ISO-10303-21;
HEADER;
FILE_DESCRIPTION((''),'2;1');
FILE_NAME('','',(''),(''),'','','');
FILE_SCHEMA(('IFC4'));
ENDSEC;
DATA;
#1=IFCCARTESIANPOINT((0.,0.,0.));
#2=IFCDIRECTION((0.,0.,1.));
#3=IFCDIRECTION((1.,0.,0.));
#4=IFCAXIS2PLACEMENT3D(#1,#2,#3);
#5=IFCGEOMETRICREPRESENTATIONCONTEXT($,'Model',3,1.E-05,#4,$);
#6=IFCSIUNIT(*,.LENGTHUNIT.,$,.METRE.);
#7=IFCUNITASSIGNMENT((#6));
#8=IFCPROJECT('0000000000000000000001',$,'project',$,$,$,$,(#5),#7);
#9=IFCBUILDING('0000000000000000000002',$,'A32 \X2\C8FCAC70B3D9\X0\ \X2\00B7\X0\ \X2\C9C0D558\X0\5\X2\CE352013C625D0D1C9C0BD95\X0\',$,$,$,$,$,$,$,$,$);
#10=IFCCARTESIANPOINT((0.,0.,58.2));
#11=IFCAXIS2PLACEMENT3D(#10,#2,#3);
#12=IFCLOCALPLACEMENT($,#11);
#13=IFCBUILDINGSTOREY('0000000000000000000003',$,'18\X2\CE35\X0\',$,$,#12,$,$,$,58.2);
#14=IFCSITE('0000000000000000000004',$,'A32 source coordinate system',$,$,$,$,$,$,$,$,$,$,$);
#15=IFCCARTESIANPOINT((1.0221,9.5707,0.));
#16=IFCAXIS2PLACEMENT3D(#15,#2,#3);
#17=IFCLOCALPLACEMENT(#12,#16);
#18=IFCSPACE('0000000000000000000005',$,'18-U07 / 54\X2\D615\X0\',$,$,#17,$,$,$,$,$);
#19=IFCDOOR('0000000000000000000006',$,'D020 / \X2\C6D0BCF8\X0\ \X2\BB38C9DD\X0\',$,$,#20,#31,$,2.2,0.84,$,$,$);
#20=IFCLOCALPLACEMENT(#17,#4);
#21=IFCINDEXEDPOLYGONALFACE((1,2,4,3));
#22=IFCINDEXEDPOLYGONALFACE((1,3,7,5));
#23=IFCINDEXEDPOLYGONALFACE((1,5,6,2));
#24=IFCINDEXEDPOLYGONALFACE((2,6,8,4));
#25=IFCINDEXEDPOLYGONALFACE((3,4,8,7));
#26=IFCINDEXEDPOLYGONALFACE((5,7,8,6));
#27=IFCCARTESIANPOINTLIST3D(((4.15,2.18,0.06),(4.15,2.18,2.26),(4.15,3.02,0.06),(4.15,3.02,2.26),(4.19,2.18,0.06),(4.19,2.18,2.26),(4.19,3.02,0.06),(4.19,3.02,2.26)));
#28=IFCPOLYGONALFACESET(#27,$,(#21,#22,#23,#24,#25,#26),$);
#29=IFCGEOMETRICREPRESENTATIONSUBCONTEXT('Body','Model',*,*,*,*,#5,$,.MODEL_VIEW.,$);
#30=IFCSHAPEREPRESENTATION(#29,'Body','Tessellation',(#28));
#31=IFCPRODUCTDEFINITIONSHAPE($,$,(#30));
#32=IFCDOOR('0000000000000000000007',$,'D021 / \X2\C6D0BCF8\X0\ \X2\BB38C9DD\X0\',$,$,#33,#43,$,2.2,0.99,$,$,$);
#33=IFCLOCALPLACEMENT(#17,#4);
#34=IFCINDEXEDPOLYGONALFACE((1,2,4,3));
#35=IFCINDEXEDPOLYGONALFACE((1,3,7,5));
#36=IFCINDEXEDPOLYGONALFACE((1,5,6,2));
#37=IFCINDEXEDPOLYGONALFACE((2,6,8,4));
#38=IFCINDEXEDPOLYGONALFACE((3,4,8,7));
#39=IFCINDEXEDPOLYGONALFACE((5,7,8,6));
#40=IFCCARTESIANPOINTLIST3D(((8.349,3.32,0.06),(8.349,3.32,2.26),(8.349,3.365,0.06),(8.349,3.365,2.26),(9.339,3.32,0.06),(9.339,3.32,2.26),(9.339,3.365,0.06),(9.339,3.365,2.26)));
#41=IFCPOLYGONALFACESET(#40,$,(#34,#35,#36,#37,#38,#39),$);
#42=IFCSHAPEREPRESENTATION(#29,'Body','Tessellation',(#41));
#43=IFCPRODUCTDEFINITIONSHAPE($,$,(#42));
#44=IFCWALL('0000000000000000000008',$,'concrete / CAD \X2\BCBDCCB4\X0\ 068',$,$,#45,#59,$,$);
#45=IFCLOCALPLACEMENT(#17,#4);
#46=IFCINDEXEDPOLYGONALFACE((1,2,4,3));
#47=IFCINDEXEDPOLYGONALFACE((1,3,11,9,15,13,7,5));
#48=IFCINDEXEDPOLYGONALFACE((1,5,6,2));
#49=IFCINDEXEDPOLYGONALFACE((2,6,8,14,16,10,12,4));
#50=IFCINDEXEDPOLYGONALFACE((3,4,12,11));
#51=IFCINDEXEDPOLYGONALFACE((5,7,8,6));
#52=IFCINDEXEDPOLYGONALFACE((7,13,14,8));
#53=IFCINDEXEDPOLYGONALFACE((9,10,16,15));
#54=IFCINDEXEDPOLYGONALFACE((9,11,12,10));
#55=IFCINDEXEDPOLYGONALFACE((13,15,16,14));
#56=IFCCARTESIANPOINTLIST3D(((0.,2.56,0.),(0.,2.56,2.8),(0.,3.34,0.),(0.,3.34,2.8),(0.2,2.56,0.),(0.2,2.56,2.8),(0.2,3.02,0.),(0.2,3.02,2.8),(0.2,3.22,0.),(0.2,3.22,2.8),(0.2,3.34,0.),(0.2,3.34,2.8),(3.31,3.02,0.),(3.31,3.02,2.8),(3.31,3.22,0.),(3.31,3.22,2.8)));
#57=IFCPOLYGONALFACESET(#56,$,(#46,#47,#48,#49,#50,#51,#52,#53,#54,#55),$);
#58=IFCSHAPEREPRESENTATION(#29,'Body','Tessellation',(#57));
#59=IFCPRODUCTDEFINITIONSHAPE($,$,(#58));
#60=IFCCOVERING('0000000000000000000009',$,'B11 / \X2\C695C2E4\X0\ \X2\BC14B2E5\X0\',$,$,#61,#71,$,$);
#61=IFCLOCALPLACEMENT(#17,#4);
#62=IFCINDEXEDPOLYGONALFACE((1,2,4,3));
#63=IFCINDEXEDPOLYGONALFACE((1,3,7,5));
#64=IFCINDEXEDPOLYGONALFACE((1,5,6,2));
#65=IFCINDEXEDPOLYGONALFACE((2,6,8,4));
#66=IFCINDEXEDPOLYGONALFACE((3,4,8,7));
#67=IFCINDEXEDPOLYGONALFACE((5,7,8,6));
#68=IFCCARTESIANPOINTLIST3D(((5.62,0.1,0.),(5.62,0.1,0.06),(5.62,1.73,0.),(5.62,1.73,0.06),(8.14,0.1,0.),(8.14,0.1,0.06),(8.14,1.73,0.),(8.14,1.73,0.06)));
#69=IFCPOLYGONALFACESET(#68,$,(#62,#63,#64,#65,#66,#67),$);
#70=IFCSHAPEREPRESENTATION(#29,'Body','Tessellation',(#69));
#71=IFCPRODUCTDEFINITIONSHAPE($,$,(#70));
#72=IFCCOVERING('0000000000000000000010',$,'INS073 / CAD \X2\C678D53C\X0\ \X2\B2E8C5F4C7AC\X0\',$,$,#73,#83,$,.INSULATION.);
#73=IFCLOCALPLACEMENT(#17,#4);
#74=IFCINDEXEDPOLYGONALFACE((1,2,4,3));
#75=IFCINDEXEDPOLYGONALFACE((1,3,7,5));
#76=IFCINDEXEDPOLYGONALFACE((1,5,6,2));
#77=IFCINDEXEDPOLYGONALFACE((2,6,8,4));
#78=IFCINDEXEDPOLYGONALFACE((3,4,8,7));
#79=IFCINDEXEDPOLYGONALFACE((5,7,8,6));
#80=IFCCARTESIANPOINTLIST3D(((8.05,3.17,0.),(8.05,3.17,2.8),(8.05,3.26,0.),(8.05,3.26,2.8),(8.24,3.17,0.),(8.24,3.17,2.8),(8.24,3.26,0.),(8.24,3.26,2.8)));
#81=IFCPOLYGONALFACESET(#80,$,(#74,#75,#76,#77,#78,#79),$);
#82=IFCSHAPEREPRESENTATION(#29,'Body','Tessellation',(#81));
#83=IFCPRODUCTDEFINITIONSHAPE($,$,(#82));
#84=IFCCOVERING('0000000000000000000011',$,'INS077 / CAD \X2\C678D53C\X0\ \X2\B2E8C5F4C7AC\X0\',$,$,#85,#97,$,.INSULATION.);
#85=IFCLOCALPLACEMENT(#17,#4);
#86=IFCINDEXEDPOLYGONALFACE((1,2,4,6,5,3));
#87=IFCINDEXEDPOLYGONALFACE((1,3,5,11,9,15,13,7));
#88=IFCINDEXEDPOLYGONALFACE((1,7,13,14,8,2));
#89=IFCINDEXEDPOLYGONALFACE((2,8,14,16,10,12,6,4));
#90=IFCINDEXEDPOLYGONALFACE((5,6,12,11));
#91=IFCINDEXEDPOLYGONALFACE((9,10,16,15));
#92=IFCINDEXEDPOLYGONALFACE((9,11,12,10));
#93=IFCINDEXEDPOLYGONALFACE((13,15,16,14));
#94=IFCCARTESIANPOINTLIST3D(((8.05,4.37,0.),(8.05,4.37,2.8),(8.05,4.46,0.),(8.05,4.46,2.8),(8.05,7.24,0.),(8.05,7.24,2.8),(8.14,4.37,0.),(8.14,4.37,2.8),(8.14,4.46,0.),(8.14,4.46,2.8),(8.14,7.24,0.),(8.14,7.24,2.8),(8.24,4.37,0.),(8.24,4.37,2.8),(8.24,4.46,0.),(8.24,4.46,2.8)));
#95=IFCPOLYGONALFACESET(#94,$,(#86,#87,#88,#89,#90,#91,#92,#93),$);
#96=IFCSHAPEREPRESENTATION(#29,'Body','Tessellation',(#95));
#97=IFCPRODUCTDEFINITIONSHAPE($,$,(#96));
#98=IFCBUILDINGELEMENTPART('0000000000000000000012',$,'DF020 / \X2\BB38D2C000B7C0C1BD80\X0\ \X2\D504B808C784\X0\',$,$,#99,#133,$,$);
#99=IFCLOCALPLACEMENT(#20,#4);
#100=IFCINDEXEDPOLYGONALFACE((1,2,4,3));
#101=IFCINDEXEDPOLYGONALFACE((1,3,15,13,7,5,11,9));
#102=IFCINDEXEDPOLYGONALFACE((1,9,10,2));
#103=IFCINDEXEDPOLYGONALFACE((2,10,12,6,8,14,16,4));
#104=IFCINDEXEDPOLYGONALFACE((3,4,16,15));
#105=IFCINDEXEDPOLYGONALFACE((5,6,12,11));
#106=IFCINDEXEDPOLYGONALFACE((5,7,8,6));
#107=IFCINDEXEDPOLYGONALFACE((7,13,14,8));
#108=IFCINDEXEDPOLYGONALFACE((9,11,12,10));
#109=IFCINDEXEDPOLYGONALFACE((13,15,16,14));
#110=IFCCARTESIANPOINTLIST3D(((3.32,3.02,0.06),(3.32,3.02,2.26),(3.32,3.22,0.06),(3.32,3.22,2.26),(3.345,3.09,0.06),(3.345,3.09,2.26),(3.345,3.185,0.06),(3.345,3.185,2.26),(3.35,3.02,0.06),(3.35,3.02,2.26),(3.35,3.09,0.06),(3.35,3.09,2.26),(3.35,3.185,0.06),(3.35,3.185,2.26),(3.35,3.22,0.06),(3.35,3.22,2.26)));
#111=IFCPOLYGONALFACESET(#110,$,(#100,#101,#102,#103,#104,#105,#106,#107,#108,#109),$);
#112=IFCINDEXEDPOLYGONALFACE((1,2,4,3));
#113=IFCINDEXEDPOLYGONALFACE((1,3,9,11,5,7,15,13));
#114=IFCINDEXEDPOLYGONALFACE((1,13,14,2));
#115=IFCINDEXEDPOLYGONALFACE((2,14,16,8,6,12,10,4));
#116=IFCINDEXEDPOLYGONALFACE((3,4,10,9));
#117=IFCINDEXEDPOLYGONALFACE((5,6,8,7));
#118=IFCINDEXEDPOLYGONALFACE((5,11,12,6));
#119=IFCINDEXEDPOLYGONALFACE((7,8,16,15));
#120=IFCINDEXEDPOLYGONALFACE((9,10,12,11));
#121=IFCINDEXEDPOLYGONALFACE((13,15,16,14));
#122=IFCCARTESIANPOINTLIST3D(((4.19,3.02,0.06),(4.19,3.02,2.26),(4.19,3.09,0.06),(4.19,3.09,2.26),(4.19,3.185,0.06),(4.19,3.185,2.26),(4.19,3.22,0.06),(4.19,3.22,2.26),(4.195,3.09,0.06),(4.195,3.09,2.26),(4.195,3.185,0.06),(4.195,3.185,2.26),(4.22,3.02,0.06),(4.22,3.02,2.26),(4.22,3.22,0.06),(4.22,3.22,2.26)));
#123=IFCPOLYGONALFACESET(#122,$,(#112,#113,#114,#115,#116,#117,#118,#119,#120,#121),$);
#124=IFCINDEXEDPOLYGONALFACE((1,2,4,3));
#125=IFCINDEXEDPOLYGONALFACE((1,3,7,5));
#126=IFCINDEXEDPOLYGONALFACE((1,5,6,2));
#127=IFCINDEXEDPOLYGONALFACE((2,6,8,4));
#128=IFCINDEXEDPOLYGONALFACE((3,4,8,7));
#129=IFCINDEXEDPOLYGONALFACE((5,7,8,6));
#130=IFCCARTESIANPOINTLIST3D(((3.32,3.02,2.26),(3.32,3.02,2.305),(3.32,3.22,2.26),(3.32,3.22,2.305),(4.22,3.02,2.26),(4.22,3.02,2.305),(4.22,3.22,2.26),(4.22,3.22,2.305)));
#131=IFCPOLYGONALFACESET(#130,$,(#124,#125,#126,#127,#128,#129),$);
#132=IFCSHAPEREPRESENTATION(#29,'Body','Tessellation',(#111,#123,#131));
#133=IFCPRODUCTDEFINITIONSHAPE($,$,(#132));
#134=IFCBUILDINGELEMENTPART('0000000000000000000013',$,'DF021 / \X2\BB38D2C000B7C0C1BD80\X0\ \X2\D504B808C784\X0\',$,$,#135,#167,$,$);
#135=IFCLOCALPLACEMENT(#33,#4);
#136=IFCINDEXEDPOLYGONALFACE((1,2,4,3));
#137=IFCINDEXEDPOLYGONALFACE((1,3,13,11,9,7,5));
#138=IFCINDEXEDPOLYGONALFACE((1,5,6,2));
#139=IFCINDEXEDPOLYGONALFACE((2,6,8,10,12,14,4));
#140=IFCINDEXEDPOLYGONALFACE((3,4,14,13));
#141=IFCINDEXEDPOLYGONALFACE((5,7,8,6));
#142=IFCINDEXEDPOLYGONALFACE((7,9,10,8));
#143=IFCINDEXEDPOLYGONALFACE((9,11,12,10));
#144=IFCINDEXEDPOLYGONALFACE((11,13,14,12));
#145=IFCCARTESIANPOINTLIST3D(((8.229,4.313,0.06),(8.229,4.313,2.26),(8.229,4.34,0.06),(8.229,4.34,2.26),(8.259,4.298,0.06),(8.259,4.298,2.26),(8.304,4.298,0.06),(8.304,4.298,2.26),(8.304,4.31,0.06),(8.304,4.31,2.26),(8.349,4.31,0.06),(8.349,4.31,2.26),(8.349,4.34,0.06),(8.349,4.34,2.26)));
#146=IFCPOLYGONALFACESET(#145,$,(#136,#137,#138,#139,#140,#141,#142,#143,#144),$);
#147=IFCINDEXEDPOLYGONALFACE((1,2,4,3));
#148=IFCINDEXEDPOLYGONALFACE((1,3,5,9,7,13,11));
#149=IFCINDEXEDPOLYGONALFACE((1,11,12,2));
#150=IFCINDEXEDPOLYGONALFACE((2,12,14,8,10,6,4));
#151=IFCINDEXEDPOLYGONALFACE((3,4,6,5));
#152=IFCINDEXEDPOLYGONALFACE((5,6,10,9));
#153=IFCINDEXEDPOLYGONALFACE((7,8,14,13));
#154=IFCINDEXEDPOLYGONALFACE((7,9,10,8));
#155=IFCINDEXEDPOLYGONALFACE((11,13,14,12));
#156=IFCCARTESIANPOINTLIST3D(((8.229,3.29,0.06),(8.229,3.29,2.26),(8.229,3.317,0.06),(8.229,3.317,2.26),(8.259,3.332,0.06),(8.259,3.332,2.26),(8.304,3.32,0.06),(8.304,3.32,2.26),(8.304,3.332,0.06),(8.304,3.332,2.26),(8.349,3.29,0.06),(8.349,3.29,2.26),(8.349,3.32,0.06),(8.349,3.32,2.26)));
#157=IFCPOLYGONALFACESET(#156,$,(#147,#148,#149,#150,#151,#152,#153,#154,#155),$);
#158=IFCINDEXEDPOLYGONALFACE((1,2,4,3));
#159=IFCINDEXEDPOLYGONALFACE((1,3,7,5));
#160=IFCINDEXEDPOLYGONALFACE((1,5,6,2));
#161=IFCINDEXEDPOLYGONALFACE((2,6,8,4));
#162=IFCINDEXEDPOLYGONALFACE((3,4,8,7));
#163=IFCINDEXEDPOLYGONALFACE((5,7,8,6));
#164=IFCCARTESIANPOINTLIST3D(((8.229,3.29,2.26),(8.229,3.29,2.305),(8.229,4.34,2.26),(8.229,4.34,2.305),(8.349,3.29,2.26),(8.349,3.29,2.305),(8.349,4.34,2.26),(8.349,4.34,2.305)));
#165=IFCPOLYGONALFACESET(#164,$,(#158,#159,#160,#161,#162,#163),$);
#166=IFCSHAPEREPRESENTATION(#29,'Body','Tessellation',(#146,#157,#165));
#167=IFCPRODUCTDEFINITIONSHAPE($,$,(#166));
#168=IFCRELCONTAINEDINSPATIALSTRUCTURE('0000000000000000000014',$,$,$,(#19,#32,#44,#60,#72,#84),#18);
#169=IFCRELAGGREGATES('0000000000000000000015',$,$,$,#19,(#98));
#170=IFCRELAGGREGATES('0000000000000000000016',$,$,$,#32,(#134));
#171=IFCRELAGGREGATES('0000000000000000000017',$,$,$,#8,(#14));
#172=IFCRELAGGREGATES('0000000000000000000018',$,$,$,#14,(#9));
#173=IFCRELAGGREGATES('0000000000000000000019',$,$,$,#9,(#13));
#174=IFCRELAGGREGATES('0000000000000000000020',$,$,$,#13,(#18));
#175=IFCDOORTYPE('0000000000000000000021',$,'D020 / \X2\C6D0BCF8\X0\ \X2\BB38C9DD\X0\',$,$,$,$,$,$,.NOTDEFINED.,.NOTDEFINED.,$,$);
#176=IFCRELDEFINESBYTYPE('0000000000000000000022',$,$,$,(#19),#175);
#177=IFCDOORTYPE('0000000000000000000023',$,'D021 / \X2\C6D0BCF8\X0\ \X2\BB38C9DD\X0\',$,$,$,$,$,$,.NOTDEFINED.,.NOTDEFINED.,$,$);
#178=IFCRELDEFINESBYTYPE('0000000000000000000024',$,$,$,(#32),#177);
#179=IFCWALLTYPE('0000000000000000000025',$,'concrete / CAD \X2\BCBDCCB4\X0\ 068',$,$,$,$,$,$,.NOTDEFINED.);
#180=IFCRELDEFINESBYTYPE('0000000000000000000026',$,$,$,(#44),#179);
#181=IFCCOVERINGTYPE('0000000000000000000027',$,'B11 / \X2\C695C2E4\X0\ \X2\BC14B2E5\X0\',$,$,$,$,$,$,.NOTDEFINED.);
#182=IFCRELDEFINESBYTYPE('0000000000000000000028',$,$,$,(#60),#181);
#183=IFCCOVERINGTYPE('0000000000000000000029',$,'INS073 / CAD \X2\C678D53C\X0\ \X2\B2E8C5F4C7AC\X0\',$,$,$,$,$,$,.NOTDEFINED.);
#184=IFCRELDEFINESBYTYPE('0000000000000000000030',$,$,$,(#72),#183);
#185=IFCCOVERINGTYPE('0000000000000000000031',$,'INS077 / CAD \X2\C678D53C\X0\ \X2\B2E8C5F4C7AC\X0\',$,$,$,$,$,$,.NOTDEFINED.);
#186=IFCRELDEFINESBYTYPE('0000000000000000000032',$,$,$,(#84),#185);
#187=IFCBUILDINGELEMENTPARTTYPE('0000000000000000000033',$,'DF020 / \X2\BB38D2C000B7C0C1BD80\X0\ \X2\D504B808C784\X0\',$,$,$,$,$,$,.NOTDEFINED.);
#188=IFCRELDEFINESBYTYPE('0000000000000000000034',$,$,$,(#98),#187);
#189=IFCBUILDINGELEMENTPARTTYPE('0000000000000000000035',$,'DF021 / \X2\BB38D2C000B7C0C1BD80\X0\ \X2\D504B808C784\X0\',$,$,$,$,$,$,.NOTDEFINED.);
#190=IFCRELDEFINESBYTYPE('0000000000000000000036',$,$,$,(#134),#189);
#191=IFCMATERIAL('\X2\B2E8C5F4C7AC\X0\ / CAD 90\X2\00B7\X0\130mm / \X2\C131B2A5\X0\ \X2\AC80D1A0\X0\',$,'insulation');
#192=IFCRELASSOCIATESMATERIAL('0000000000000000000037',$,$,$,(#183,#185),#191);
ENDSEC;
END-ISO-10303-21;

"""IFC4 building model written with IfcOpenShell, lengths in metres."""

from ifc_helpers import new_model, si_unit, frame, origin, origin_with_axes, place, context, subcontext, project, spatial, polyline, outline, extrude, source, transform, mapped, material, type_object, type_shapes, element, aggregate, save


model = new_model("IFC4")

# Units and contexts
model_context = context("Model", 3, precision=1e-05, world=origin_with_axes())
body_context = subcontext(model_context, "Body", "Model", "MODEL_VIEW")
ifc_project = project(units=[si_unit("LENGTHUNIT", "METRE")], contexts=[model_context])

# Site, building, storey, space
storey_placement = place(None, frame((0.0, 0.0, 58.2), z_axis=(0.0, 0.0, 1.0), x_axis=(1.0, 0.0, 0.0)))
space_placement = place(storey_placement, frame((1.0221, 9.5707, 0.0), z_axis=(0.0, 0.0, 1.0), x_axis=(1.0, 0.0, 0.0)))
site = spatial("IfcSite", under=ifc_project, Name="A32 source coordinate system")
building = spatial("IfcBuilding", under=site, Name="A32 주거동 · 지하5층–옥탑지붕")
storey = spatial("IfcBuildingStorey", under=building, at=storey_placement, Name="18층", Elevation=58.2)
space = spatial("IfcSpace", under=storey, at=space_placement, Name="18-U07 / 54형")

# Doors
door_type_1 = type_object("IfcDoorType", Name="D020 / 원본 문짝", OperationType="NOTDEFINED", PredefinedType="NOTDEFINED")
shared_shape_1 = source(origin(), body_context, "Body", "SweptSolid", [
    extrude(outline(polyline([(4.19, 3.02), (4.19, 2.18), (4.15, 2.18), (4.15, 3.02), (4.19, 3.02)])), frame((0.0, 0.0, 0.06)), (0.0, 0.0, 1.0), 2.2),
])
type_shapes(door_type_1, [shared_shape_1])
door_1_placement = place(space_placement, origin_with_axes())
door_1 = element("IfcDoor", 1, at=door_1_placement, inside=space, type_object=door_type_1, Name="D020 / 원본 문짝", OverallHeight=2.2, OverallWidth=0.84, context=body_context, shape_type="MappedRepresentation", body=[
    mapped(shared_shape_1, transform((0.0, 0.0, 0.0), scale=1.0)),
])
door_type_2 = type_object("IfcDoorType", Name="D021 / 원본 문짝", OperationType="NOTDEFINED", PredefinedType="NOTDEFINED")
shared_shape_2 = source(origin(), body_context, "Body", "SweptSolid", [
    extrude(outline(polyline([(9.339, 3.365), (9.339, 3.32), (8.349, 3.32), (8.349, 3.365), (9.339, 3.365)])), frame((0.0, 0.0, 0.06)), (0.0, 0.0, 1.0), 2.2),
])
type_shapes(door_type_2, [shared_shape_2])
door_2_placement = place(space_placement, origin_with_axes())
door_2 = element("IfcDoor", 2, at=door_2_placement, inside=space, type_object=door_type_2, Name="D021 / 원본 문짝", OverallHeight=2.2, OverallWidth=0.99, context=body_context, shape_type="MappedRepresentation", body=[
    mapped(shared_shape_2, transform((0.0, 0.0, 0.0), scale=1.0)),
])

# Wall
wall_type_1 = type_object("IfcWallType", Name="concrete / CAD 벽체 068", PredefinedType="NOTDEFINED")
shared_shape_3 = source(origin(), body_context, "Body", "SweptSolid", [
    extrude(outline(polyline([(0.2, 3.02), (0.2, 2.56), (0.0, 2.56), (0.0, 3.34), (0.2, 3.34), (0.2, 3.22), (3.31, 3.22), (3.31, 3.02), (0.2, 3.02)])), origin(), (0.0, 0.0, 1.0), 2.8),
])
type_shapes(wall_type_1, [shared_shape_3])
wall_1_placement = place(space_placement, origin_with_axes())
element("IfcWall", 3, at=wall_1_placement, inside=space, type_object=wall_type_1, Name="concrete / CAD 벽체 068", context=body_context, shape_type="MappedRepresentation", body=[
    mapped(shared_shape_3, transform((0.0, 0.0, 0.0), scale=1.0)),
])

# Coverings
covering_type_1 = type_object("IfcCoveringType", Name="B11 / 욕실 바닥", PredefinedType="NOTDEFINED")
shared_shape_4 = source(origin(), body_context, "Body", "SweptSolid", [
    extrude(outline(polyline([(8.14, 1.73), (8.14, 0.1), (5.62, 0.1), (5.62, 1.73), (8.14, 1.73)])), origin(), (0.0, 0.0, 1.0), 0.06),
])
type_shapes(covering_type_1, [shared_shape_4])
covering_1_placement = place(space_placement, origin_with_axes())
element("IfcCovering", 4, at=covering_1_placement, inside=space, type_object=covering_type_1, Name="B11 / 욕실 바닥", context=body_context, shape_type="MappedRepresentation", body=[
    mapped(shared_shape_4, transform((0.0, 0.0, 0.0), scale=1.0)),
])
ifc_material = material(Name="단열재 / CAD 90·130mm / 성능 검토", Category="insulation")
covering_type_2 = type_object("IfcCoveringType", Name="INS073 / CAD 외피 단열재", PredefinedType="NOTDEFINED", material=ifc_material)
shared_shape_5 = source(origin(), body_context, "Body", "SweptSolid", [
    extrude(outline(polyline([(8.05, 3.17), (8.05, 3.26), (8.24, 3.26), (8.24, 3.17), (8.05, 3.17)])), origin(), (0.0, 0.0, 1.0), 2.8),
])
type_shapes(covering_type_2, [shared_shape_5])
covering_2_placement = place(space_placement, origin_with_axes())
element("IfcCovering", 5, at=covering_2_placement, inside=space, type_object=covering_type_2, Name="INS073 / CAD 외피 단열재", PredefinedType="INSULATION", context=body_context, shape_type="MappedRepresentation", body=[
    mapped(shared_shape_5, transform((0.0, 0.0, 0.0), scale=1.0)),
])
covering_type_3 = type_object("IfcCoveringType", Name="INS077 / CAD 외피 단열재", PredefinedType="NOTDEFINED", material=ifc_material)
shared_shape_6 = source(origin(), body_context, "Body", "SweptSolid", [
    extrude(outline(polyline([(8.24, 4.37), (8.14, 4.37), (8.05, 4.37), (8.05, 4.46), (8.05, 7.24), (8.14, 7.24), (8.14, 4.46), (8.24, 4.46), (8.24, 4.37)])), origin(), (0.0, 0.0, 1.0), 2.8),
])
type_shapes(covering_type_3, [shared_shape_6])
covering_3_placement = place(space_placement, origin_with_axes())
element("IfcCovering", 6, at=covering_3_placement, inside=space, type_object=covering_type_3, Name="INS077 / CAD 외피 단열재", PredefinedType="INSULATION", context=body_context, shape_type="MappedRepresentation", body=[
    mapped(shared_shape_6, transform((0.0, 0.0, 0.0), scale=1.0)),
])

# Building element parts
building_element_part_type_1 = type_object("IfcBuildingElementPartType", Name="DF020 / 문틀·상부 프레임", PredefinedType="NOTDEFINED")
shared_shape_7 = source(origin(), body_context, "Body", "SweptSolid", [
    extrude(outline(polyline([(3.32, 3.22), (3.35, 3.22), (3.35, 3.185), (3.345, 3.185), (3.345, 3.09), (3.35, 3.09), (3.35, 3.02), (3.32, 3.02), (3.32, 3.22)])), frame((0.0, 0.0, 0.06)), (0.0, 0.0, 1.0), 2.2),
    extrude(outline(polyline([(4.19, 3.02), (4.19, 3.09), (4.195, 3.09), (4.195, 3.185), (4.19, 3.185), (4.19, 3.22), (4.22, 3.22), (4.22, 3.02), (4.19, 3.02)])), frame((0.0, 0.0, 0.06)), (0.0, 0.0, 1.0), 2.2),
    extrude(outline(polyline([(3.32, 3.02), (3.32, 3.22), (4.22, 3.22), (4.22, 3.02), (3.32, 3.02)])), frame((0.0, 0.0, 2.26)), (0.0, 0.0, 1.0), 0.045),
])
type_shapes(building_element_part_type_1, [shared_shape_7])
building_element_part_1_placement = place(door_1_placement, origin_with_axes())
building_element_part_1 = element("IfcBuildingElementPart", 7, at=building_element_part_1_placement, type_object=building_element_part_type_1, Name="DF020 / 문틀·상부 프레임", context=body_context, shape_type="MappedRepresentation", body=[
    mapped(shared_shape_7, transform((0.0, 0.0, 0.0), scale=1.0)),
])
aggregate(door_1, [building_element_part_1])
building_element_part_type_2 = type_object("IfcBuildingElementPartType", Name="DF021 / 문틀·상부 프레임", PredefinedType="NOTDEFINED")
shared_shape_8 = source(origin(), body_context, "Body", "SweptSolid", [
    extrude(outline(polyline([(8.349, 4.31), (8.304, 4.31), (8.304, 4.298), (8.259, 4.298), (8.229, 4.313), (8.229, 4.34), (8.349, 4.34), (8.349, 4.31)])), frame((0.0, 0.0, 0.06)), (0.0, 0.0, 1.0), 2.2),
    extrude(outline(polyline([(8.229, 3.29), (8.229, 3.317), (8.259, 3.332), (8.304, 3.332), (8.304, 3.32), (8.349, 3.32), (8.349, 3.29), (8.229, 3.29)])), frame((0.0, 0.0, 0.06)), (0.0, 0.0, 1.0), 2.2),
    extrude(outline(polyline([(8.229, 3.29), (8.229, 4.34), (8.349, 4.34), (8.349, 3.29), (8.229, 3.29)])), frame((0.0, 0.0, 2.26)), (0.0, 0.0, 1.0), 0.045),
])
type_shapes(building_element_part_type_2, [shared_shape_8])
building_element_part_2_placement = place(door_2_placement, origin_with_axes())
building_element_part_2 = element("IfcBuildingElementPart", 8, at=building_element_part_2_placement, type_object=building_element_part_type_2, Name="DF021 / 문틀·상부 프레임", context=body_context, shape_type="MappedRepresentation", body=[
    mapped(shared_shape_8, transform((0.0, 0.0, 0.0), scale=1.0)),
])
aggregate(door_2, [building_element_part_2])

save(model, "model.ifc")
